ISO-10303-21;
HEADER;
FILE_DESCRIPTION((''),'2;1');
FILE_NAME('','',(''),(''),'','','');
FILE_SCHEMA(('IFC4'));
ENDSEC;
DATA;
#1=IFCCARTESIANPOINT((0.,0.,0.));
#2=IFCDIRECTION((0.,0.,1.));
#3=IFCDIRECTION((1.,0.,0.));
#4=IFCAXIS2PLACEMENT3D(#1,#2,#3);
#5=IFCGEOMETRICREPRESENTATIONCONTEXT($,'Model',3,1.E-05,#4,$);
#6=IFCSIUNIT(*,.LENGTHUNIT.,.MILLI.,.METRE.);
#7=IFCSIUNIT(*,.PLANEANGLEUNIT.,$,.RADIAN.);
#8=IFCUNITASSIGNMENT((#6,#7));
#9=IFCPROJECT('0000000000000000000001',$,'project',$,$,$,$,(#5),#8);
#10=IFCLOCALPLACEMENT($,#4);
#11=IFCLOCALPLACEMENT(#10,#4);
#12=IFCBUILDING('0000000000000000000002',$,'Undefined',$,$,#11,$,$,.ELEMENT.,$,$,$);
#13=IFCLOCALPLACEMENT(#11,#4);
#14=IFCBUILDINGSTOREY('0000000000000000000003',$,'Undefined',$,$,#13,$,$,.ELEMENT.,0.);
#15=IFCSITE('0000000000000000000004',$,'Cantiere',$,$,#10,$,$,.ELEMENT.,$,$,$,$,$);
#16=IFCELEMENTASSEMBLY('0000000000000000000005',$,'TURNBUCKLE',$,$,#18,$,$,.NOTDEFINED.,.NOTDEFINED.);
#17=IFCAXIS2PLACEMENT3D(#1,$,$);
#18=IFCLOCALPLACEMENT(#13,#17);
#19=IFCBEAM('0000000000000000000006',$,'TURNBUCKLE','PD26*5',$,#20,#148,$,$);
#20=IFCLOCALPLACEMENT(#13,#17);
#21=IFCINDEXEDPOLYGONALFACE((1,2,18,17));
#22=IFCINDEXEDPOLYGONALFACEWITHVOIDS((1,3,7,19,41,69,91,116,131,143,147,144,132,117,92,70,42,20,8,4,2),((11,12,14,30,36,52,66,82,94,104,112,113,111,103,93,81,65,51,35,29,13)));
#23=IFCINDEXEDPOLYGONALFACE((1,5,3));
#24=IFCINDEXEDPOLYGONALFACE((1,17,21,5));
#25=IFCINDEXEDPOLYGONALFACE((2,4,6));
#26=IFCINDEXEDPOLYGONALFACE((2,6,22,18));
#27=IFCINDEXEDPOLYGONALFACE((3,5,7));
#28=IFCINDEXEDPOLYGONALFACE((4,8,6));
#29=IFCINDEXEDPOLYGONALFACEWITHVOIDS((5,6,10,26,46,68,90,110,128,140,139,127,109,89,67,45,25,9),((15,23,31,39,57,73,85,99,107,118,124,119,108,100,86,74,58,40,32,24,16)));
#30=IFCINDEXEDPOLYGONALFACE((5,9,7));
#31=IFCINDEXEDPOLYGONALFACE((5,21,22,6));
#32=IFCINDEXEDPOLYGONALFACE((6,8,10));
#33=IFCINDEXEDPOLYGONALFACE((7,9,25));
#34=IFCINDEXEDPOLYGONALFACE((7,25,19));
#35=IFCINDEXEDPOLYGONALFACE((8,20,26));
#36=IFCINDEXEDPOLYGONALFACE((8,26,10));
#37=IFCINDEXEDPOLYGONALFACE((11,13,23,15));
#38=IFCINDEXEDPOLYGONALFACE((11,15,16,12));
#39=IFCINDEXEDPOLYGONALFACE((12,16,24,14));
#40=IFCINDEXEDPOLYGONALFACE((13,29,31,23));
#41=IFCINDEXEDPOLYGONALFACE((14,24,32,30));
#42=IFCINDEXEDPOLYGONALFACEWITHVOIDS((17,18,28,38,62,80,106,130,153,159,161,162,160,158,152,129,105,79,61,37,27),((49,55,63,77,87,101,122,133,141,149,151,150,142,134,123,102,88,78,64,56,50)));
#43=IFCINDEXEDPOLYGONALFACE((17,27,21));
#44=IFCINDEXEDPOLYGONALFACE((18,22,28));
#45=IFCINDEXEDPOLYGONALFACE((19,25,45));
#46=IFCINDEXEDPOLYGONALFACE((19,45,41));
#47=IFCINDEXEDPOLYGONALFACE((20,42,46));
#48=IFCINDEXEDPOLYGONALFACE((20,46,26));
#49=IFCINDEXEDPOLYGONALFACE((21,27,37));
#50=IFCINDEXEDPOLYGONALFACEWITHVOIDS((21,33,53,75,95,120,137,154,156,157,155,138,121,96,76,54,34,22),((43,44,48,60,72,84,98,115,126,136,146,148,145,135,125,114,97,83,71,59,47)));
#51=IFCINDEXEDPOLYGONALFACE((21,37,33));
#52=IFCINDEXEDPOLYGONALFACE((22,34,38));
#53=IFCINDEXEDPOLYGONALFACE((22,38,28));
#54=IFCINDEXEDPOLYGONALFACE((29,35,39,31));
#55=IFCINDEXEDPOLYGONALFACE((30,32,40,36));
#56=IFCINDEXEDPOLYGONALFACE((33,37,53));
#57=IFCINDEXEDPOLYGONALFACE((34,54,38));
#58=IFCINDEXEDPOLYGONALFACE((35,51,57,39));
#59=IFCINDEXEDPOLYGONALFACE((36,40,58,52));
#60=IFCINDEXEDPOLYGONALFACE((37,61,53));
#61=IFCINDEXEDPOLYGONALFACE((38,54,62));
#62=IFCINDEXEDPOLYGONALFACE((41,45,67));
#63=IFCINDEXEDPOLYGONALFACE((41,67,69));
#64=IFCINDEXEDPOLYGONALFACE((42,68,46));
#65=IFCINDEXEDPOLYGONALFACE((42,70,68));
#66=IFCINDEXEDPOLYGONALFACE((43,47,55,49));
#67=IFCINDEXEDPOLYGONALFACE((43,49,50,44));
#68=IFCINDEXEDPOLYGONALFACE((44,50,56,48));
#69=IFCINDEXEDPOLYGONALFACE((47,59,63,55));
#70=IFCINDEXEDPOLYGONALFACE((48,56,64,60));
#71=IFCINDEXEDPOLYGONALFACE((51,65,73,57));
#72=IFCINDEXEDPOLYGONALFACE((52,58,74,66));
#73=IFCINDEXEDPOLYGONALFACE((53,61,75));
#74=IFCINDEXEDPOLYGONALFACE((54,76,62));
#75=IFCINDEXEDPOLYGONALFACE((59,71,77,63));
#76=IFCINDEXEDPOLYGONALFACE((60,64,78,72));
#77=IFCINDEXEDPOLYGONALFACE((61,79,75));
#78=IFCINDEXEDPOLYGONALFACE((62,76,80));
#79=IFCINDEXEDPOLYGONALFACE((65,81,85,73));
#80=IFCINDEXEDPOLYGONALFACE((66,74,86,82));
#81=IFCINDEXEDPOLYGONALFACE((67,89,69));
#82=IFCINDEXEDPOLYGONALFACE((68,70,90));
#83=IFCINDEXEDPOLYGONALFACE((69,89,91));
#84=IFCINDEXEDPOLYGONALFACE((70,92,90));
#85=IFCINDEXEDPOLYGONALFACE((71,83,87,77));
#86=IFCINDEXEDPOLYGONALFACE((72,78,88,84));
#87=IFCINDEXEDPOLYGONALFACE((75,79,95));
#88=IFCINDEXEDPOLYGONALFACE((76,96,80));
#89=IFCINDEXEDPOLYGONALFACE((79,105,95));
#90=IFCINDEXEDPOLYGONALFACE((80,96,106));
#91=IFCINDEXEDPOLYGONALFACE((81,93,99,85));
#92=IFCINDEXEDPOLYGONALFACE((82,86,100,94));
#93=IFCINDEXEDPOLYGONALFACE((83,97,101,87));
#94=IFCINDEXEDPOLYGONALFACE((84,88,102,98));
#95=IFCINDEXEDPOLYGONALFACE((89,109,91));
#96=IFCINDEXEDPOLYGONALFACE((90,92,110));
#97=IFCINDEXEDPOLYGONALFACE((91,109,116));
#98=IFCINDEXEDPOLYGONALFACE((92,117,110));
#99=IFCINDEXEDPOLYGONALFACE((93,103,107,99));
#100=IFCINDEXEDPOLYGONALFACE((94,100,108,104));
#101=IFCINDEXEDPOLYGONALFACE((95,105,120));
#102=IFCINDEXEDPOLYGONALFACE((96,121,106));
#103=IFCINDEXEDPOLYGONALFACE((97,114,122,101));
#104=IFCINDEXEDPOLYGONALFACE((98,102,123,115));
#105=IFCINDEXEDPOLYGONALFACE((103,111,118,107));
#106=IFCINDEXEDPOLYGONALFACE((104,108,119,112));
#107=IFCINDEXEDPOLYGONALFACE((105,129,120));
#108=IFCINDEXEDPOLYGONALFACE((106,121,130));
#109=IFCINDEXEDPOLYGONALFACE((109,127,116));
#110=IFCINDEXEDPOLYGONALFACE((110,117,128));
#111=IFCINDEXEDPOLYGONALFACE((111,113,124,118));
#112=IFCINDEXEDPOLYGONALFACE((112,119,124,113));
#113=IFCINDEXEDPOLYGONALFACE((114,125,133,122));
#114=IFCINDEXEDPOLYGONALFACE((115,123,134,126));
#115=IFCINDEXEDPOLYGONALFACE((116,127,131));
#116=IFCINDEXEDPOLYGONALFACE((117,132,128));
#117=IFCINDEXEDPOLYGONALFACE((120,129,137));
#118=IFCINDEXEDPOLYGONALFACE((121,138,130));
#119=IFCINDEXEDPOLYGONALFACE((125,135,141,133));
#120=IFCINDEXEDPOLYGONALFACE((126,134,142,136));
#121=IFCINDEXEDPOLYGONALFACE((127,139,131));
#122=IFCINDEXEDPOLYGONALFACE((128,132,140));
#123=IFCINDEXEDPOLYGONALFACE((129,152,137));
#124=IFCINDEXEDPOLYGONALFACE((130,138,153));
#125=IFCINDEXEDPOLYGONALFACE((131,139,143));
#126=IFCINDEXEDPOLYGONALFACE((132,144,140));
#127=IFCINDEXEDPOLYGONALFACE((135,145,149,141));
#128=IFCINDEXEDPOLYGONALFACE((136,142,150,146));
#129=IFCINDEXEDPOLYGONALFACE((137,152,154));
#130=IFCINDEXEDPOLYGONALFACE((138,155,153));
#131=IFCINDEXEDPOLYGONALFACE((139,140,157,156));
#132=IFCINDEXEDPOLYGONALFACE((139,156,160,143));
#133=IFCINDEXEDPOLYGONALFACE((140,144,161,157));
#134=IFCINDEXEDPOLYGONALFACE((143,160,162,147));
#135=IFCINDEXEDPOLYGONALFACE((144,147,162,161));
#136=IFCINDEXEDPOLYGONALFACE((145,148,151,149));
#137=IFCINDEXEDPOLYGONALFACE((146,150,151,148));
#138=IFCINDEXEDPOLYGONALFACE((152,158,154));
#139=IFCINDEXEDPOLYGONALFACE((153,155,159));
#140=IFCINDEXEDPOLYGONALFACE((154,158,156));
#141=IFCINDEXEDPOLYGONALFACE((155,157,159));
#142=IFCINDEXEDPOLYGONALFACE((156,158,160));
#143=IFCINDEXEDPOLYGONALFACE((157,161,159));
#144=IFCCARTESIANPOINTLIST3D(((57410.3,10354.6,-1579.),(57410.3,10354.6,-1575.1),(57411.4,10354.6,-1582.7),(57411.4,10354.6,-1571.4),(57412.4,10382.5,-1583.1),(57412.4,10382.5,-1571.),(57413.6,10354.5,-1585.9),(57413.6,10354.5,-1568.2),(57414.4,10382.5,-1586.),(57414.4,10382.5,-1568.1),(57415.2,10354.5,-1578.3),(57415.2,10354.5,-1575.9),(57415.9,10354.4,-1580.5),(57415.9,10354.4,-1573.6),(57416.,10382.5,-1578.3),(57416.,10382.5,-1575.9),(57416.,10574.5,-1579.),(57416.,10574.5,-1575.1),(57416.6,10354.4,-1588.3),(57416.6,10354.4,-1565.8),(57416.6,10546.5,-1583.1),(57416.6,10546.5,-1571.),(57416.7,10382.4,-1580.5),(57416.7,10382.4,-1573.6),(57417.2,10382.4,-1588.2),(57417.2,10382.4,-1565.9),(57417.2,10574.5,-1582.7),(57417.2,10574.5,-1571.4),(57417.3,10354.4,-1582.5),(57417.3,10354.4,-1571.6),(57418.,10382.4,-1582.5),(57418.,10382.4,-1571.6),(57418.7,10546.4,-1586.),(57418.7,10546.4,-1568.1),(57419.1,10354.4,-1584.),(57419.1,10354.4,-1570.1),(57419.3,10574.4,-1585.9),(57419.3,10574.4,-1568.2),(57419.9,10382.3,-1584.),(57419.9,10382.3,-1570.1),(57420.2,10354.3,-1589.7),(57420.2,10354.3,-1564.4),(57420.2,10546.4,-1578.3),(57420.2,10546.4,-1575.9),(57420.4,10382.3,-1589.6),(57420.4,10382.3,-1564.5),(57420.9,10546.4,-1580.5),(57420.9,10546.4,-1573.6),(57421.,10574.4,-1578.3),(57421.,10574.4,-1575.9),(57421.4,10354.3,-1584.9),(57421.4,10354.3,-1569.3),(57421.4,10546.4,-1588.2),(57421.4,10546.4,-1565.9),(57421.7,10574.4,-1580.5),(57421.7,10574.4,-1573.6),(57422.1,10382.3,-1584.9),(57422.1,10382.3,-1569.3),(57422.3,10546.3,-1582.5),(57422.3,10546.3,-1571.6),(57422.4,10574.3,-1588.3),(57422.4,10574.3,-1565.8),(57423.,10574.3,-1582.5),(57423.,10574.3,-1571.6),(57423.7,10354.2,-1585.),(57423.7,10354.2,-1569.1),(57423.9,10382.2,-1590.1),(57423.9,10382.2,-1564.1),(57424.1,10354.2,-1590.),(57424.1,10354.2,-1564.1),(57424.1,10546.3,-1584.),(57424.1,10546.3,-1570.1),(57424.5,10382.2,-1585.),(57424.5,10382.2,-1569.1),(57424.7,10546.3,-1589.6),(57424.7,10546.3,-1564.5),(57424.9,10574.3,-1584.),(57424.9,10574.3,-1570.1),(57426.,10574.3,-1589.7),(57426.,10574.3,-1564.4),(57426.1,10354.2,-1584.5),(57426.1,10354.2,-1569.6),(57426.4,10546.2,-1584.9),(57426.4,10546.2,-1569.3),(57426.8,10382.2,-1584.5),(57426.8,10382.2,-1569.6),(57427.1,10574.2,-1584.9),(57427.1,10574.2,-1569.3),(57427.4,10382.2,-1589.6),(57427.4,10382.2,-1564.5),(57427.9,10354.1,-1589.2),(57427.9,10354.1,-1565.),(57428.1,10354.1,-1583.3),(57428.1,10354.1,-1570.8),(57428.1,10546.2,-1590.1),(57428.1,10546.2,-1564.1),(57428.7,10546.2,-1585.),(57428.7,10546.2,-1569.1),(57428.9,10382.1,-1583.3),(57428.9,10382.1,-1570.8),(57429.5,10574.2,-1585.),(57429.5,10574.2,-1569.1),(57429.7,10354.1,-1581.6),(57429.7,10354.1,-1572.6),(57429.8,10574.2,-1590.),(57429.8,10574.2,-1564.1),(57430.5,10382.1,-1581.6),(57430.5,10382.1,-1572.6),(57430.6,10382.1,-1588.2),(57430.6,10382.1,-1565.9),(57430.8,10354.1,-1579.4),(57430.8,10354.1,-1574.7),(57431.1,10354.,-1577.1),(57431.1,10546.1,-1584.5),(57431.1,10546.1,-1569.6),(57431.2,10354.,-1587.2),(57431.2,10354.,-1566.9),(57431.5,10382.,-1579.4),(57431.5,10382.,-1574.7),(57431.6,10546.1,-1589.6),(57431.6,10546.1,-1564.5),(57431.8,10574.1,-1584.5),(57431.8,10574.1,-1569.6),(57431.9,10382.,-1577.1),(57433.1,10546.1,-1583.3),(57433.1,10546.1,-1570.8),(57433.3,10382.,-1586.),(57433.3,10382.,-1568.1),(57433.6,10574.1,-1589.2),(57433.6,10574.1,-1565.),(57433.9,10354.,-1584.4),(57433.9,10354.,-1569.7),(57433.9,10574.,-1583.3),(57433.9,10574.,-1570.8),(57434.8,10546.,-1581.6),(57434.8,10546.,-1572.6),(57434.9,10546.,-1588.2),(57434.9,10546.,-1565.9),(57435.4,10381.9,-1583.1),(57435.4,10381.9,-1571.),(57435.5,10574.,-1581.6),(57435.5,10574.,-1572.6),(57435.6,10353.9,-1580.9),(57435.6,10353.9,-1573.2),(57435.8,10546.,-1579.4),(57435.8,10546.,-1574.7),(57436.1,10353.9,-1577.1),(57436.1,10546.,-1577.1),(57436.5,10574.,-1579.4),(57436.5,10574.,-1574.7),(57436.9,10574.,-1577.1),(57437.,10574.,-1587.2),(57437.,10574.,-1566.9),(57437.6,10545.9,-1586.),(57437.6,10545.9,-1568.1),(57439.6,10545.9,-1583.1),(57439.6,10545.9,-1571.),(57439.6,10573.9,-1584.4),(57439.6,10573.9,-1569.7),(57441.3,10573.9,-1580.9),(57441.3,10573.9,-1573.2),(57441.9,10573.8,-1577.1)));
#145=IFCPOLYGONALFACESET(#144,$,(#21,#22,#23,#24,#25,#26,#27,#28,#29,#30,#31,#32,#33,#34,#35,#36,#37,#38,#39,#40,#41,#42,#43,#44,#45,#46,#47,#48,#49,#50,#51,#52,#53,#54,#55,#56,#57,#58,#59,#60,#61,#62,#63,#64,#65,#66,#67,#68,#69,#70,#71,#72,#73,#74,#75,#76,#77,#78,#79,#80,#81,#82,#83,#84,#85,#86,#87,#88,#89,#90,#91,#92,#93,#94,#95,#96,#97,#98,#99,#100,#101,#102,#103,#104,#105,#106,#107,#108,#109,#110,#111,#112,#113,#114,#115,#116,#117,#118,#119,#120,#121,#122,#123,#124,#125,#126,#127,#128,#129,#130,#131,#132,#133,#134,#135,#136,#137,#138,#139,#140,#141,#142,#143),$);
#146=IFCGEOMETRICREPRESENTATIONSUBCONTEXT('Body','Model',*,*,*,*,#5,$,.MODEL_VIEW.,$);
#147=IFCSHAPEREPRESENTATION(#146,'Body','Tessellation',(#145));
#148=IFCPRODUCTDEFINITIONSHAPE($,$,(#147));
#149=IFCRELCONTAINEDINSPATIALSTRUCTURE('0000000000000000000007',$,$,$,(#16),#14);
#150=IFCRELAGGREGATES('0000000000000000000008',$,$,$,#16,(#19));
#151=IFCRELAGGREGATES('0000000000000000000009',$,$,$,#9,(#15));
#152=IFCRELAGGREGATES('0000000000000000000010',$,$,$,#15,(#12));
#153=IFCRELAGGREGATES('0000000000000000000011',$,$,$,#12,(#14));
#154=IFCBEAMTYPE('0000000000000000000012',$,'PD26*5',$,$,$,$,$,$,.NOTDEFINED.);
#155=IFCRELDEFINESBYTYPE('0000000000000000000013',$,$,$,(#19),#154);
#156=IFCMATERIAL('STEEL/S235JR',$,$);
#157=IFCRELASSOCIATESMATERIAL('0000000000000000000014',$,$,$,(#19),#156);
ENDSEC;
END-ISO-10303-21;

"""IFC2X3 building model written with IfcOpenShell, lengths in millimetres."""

from ifc_helpers import new_model, si_unit, frame, origin_with_axes, origin_2d_with_axis, place, context, subcontext, project, spatial, rectangle, hollow_circle, extrude, boolean, material, type_object, element, aggregate, save


model = new_model("IFC2X3")

# Units and contexts
model_context = context("Model", 3, precision=1e-05, world=origin_with_axes())
body_context = subcontext(model_context, "Body", "Model", "MODEL_VIEW")
ifc_project = project(units=[si_unit("LENGTHUNIT", "METRE", prefix="MILLI"), si_unit("PLANEANGLEUNIT", "RADIAN")], contexts=[model_context])

# Site, building, storey
site_placement = place(None, origin_with_axes())
site = spatial("IfcSite", under=ifc_project, at=site_placement, Name="Cantiere", CompositionType="ELEMENT")
building_placement = place(site_placement, origin_with_axes())
building = spatial("IfcBuilding", under=site, at=building_placement, Name="Undefined", CompositionType="ELEMENT")
storey_placement = place(building_placement, origin_with_axes())
storey = spatial("IfcBuildingStorey", under=building, at=storey_placement, Name="Undefined", CompositionType="ELEMENT", Elevation=0.0)

# Shared definitions
ifc_material_1 = material(Name="STEEL/S235JR")

# Element assembly, beam
assembly_1_placement = place(storey_placement, origin_with_axes())
assembly_1 = element("IfcElementAssembly", 1, at=assembly_1_placement, inside=storey, Name="TURNBUCKLE", AssemblyPlace="NOTDEFINED", PredefinedType="NOTDEFINED")
beam_type_1 = type_object("IfcBeamType", Name="PD26*5", PredefinedType="NOTDEFINED")
beam_1_placement = place(assembly_1_placement, frame((57428.9, 10574.2, -1577.1), z_axis=(0.0, 0.000001, -1.0), x_axis=(-0.026057, -0.99966, -0.000001)))
beam_1 = element("IfcBeam", 2, at=beam_1_placement, type_object=beam_type_1, material=ifc_material_1, Name="TURNBUCKLE", Description="PD26*5", context=body_context, shape_type="CSG", body=[
    boolean("DIFFERENCE", extrude(hollow_circle(Radius=13.0, WallThickness=5.0, at=origin_2d_with_axis()), frame((220.0, 0.0, 0.0), z_axis=(-1.0, 0.0, 0.0), x_axis=(0.0, -1.0, 0.0)), (0.0, 0.0, 1.0), 220.0), extrude(rectangle(XDim=23.0, YDim=68.0, at=origin_2d_with_axis()), frame((192.0, 0.0, 0.0), z_axis=(-1.0, 0.0, 0.0), x_axis=(0.0, -1.0, 0.0)), (0.0, 0.0, 1.0), 164.0)),
])
aggregate(assembly_1, [beam_1])

save(model, "model.ifc")
